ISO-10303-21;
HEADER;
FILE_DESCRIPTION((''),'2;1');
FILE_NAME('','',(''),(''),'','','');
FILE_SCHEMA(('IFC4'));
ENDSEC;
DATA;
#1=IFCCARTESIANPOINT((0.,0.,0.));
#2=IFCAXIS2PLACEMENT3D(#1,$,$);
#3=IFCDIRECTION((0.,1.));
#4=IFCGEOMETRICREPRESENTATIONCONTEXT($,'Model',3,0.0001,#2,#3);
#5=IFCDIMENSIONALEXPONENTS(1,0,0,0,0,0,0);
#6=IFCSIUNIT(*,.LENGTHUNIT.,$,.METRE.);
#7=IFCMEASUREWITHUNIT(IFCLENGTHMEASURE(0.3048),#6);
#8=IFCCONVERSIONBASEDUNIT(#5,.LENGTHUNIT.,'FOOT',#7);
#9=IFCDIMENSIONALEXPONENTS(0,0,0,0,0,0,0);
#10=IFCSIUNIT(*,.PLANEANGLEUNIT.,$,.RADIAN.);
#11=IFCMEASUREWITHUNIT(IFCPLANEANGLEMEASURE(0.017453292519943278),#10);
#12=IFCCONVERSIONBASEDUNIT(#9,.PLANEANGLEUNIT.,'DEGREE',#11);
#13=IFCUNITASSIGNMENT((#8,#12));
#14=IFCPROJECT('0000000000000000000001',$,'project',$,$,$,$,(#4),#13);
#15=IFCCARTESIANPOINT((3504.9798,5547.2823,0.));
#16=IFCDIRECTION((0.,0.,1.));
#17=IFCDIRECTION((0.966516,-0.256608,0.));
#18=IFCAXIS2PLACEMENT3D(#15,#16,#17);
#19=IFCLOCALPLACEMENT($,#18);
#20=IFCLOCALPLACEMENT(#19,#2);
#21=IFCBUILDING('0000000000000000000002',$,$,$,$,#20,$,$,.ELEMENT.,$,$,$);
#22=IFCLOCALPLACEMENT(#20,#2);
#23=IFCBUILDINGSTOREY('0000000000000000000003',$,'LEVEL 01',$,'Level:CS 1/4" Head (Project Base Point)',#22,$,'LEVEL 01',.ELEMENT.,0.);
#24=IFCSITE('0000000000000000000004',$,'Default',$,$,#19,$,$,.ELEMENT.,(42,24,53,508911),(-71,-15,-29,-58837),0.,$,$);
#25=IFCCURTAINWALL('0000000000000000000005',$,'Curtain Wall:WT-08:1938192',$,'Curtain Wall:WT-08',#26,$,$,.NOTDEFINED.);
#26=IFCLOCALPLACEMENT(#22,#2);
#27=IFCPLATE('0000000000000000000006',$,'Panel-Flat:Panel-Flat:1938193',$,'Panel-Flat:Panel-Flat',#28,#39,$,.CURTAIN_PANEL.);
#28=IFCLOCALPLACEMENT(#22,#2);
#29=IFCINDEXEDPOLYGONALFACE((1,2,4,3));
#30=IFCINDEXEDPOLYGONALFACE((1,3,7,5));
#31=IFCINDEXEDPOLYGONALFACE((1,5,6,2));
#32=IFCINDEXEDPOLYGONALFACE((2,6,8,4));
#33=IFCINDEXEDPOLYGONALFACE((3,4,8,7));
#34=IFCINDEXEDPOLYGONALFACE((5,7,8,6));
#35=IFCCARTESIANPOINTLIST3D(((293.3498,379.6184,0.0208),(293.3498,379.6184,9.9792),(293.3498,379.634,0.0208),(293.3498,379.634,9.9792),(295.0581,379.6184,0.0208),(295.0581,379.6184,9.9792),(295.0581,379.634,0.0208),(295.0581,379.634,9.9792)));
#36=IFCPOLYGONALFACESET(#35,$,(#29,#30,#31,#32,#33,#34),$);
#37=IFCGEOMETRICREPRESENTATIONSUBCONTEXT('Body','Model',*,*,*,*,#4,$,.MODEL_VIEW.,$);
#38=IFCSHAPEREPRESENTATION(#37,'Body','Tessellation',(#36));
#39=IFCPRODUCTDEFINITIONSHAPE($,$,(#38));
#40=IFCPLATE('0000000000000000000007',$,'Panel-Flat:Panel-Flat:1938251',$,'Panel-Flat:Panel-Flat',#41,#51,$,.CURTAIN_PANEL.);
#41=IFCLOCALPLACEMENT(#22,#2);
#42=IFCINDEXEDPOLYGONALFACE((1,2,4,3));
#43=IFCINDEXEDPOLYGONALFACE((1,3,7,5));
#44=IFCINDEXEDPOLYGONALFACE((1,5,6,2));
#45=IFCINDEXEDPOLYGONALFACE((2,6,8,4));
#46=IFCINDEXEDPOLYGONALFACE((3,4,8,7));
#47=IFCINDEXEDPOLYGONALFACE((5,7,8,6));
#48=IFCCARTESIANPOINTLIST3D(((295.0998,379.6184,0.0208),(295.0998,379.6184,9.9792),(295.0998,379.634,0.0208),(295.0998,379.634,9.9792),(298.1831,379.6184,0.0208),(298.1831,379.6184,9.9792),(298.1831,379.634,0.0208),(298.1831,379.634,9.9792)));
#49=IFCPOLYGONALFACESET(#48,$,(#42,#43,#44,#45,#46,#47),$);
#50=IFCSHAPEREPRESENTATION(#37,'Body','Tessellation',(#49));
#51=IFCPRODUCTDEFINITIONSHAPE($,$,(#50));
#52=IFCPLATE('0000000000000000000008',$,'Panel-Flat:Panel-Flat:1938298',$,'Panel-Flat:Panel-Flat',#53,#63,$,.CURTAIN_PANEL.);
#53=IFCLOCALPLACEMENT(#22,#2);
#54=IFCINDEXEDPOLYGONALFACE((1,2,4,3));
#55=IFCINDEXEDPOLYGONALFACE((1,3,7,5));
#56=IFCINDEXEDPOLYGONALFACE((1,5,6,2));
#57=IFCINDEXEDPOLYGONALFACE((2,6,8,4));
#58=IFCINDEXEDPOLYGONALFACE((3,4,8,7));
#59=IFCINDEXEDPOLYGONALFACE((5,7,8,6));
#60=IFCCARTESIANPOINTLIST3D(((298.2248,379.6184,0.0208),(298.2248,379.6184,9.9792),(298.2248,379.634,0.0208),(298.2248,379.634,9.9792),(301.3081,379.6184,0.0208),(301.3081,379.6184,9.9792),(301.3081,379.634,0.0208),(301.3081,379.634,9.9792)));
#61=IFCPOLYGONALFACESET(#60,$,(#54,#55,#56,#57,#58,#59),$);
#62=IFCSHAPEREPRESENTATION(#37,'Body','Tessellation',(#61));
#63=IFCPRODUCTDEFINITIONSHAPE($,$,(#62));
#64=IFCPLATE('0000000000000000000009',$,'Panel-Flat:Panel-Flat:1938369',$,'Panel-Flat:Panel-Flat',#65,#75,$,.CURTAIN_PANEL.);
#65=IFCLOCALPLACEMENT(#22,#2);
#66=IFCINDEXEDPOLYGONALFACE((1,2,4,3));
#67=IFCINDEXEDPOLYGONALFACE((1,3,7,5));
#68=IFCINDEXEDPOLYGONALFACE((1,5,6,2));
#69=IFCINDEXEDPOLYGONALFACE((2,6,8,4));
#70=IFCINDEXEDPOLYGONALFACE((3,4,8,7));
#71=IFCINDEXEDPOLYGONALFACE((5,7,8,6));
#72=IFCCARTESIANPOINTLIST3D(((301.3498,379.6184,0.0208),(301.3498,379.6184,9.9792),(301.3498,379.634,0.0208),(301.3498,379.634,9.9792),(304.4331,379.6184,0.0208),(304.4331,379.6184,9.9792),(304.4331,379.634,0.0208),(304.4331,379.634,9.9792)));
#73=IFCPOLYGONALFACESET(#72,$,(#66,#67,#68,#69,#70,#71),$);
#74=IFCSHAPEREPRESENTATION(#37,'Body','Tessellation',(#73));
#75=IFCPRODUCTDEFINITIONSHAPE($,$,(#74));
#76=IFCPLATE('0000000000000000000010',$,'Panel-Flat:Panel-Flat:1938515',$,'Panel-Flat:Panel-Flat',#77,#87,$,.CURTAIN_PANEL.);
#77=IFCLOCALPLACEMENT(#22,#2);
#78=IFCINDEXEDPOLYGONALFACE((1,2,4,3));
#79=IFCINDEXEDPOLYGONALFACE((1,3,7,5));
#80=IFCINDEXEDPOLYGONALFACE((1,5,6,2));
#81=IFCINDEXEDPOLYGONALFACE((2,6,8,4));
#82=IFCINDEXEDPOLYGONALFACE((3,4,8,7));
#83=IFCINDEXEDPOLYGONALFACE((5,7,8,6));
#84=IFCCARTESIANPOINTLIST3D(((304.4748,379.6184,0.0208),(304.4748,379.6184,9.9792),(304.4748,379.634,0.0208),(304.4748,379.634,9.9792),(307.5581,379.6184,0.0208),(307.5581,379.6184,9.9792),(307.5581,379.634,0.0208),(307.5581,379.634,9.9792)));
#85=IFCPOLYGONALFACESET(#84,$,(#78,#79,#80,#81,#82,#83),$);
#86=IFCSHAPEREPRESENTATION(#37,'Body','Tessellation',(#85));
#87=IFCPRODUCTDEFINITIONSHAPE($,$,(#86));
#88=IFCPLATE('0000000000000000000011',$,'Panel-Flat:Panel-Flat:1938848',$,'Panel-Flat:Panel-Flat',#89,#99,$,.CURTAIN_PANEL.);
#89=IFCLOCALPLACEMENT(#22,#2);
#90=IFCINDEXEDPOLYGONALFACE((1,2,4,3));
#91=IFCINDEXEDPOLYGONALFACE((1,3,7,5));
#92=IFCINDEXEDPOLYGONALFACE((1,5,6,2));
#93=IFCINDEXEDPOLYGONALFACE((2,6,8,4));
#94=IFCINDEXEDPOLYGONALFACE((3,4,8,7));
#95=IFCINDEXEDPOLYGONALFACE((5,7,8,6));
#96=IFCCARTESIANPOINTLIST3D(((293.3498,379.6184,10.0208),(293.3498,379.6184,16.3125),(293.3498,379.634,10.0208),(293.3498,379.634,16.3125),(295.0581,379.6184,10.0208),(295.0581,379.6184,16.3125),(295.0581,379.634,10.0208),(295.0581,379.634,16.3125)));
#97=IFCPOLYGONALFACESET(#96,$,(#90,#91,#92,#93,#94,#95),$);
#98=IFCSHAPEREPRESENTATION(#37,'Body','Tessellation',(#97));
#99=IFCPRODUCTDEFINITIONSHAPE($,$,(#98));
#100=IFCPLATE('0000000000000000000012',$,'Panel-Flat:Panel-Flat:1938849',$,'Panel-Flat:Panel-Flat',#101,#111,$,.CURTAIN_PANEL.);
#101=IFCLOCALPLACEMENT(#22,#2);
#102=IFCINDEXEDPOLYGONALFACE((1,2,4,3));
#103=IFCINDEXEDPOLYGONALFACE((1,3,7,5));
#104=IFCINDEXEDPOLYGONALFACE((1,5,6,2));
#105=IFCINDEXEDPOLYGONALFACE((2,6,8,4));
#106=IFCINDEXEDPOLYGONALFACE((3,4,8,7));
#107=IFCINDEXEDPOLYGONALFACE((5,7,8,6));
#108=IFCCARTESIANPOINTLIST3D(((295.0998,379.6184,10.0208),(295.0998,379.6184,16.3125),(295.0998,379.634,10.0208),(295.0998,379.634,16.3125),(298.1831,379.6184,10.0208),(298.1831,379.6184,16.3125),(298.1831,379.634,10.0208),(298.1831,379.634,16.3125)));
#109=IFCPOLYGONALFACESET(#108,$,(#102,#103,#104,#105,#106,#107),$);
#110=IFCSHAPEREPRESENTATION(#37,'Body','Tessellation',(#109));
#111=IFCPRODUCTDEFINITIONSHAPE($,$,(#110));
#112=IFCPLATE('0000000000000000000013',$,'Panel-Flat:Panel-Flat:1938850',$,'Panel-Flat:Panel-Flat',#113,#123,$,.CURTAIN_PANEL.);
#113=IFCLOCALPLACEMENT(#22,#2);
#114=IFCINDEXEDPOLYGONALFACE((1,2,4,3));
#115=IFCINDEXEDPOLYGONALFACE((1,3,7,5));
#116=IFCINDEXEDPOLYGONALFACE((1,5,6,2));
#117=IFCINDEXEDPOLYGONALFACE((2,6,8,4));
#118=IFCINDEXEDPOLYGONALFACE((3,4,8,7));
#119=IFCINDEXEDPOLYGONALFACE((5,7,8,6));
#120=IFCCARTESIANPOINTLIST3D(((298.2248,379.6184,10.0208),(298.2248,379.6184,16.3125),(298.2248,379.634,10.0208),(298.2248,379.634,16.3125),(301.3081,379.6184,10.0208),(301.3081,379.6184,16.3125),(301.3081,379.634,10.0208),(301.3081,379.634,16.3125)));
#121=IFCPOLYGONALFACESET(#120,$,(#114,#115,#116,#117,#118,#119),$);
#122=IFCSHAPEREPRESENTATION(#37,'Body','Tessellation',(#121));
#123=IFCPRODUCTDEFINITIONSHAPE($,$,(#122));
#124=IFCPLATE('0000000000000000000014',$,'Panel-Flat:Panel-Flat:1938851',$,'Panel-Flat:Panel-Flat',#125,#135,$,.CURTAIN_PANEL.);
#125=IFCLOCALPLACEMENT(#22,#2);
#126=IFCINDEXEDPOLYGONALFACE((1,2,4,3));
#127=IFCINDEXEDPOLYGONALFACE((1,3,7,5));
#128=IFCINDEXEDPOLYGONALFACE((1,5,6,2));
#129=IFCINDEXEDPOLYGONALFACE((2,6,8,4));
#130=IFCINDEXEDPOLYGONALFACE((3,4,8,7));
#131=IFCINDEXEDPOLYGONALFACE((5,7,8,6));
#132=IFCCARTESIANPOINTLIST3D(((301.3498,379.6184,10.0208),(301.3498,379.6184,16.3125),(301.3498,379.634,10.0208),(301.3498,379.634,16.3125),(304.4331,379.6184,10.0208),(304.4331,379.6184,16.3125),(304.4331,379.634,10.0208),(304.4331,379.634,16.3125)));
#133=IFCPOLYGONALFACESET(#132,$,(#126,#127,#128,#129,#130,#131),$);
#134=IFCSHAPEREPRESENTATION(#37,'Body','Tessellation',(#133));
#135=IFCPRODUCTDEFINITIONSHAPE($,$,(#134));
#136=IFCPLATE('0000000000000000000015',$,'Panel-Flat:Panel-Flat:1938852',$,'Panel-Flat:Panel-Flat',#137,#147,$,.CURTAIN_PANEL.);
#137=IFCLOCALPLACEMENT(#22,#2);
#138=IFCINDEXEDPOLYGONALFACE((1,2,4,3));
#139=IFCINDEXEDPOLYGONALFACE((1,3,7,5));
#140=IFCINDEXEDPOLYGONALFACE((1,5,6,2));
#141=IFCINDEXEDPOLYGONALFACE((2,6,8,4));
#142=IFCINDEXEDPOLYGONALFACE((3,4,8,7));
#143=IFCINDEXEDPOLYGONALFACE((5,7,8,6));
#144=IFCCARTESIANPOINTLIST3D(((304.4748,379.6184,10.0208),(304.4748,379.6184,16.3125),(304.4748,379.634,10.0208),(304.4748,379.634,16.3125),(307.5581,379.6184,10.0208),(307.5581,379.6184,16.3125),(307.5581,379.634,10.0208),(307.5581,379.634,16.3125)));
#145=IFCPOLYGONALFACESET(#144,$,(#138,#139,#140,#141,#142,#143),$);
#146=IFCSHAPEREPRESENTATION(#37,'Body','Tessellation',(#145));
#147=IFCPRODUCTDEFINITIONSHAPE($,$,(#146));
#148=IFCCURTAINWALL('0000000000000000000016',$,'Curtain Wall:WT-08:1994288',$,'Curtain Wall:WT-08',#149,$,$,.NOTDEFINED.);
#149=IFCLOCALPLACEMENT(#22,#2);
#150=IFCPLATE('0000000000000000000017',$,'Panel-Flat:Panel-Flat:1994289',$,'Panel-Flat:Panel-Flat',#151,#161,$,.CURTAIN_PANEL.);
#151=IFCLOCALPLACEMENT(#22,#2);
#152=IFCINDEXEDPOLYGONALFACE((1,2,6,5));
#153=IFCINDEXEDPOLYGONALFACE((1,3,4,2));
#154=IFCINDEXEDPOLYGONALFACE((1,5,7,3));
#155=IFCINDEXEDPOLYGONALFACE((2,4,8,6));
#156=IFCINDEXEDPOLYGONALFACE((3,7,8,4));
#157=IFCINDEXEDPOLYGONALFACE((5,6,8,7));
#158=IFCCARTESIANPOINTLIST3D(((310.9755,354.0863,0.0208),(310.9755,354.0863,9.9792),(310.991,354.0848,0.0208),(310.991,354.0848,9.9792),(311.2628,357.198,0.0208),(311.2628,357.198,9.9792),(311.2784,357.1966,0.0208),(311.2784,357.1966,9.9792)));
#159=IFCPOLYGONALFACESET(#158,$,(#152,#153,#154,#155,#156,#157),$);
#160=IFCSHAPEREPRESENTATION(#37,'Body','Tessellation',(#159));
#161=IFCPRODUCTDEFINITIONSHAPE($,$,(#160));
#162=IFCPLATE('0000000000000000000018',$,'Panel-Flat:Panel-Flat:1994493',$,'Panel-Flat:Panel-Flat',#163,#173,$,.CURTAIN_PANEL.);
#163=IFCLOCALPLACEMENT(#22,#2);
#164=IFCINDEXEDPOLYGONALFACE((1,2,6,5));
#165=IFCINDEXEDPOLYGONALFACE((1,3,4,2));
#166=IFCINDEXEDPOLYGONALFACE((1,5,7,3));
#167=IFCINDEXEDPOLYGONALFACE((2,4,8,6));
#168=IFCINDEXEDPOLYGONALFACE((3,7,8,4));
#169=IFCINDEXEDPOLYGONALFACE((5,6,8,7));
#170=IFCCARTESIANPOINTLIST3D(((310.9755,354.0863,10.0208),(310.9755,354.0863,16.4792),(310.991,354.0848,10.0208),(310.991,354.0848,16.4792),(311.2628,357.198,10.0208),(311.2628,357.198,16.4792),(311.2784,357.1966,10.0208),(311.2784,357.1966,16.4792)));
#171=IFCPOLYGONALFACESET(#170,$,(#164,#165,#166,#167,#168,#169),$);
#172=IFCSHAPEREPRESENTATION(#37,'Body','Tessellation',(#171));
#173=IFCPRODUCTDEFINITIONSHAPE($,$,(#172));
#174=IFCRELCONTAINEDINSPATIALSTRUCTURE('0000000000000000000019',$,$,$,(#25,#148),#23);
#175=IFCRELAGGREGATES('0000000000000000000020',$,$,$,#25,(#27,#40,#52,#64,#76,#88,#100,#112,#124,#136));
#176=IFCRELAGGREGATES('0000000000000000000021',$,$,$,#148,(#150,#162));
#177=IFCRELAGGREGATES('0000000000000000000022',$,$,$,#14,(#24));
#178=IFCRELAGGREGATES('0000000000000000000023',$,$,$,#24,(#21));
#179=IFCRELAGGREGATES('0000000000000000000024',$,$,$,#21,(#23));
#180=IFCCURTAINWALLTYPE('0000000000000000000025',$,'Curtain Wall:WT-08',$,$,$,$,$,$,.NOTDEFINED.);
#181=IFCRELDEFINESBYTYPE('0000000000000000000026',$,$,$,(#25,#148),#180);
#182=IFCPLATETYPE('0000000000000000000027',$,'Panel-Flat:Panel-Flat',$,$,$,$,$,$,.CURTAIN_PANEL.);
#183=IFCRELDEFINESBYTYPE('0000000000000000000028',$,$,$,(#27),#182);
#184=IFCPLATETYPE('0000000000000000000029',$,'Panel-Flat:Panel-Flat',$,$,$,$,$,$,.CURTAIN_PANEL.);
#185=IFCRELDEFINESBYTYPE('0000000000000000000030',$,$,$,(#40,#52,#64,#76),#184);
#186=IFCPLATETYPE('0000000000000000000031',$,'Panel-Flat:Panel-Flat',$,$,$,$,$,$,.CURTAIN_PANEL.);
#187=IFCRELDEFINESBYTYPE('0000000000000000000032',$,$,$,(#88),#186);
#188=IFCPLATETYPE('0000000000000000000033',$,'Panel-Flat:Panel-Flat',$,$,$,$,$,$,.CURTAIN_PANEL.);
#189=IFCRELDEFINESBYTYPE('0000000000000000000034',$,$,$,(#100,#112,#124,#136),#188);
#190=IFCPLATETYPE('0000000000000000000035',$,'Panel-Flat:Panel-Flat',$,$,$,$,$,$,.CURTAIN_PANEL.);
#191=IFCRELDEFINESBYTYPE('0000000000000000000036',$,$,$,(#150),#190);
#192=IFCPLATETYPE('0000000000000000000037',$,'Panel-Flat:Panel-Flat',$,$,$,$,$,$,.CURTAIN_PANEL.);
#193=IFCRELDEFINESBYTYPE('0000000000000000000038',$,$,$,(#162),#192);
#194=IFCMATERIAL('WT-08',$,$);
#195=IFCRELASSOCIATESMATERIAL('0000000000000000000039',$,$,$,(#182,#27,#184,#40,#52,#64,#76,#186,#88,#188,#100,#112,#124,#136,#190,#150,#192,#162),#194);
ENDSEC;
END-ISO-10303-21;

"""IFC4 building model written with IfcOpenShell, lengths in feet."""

from ifc_helpers import new_model, entity, si_unit, converted_unit, direction, frame, origin, place, context, subcontext, project, spatial, indexed_curve, outline, extrude, source, transform, mapped, material, type_object, type_shapes, element, aggregate, save


model = new_model("IFC4")

# Units and contexts
model_context = context("Model", 3, precision=0.0001, world=origin(), true_north=direction((0.0, 1.0)))
body_context = subcontext(model_context, "Body", "Model", "MODEL_VIEW")
ifc_project = project(units=[converted_unit("LENGTHUNIT", "FOOT", entity("IfcLengthMeasure", 0.3048), si_unit("LENGTHUNIT", "METRE"), dimensions=[1, 0, 0, 0, 0, 0, 0]), converted_unit("PLANEANGLEUNIT", "DEGREE", entity("IfcPlaneAngleMeasure", 0.017453292519943278), si_unit("PLANEANGLEUNIT", "RADIAN"), dimensions=[0, 0, 0, 0, 0, 0, 0])], contexts=[model_context])

# Site, building, storey
site_placement = place(None, frame((3504.9798, 5547.2823, 0.0), z_axis=(0.0, 0.0, 1.0), x_axis=(0.966516, -0.256608, 0.0)))
site = spatial("IfcSite", under=ifc_project, at=site_placement, Name="Default", CompositionType="ELEMENT", RefLatitude=(42, 24, 53, 508911), RefLongitude=(-71, -15, -29, -58837), RefElevation=0.0)
building_placement = place(site_placement, origin())
building = spatial("IfcBuilding", under=site, at=building_placement, CompositionType="ELEMENT")
storey_placement = place(building_placement, origin())
storey = spatial("IfcBuildingStorey", under=building, at=storey_placement, Name="LEVEL 01", ObjectType="Level:CS 1/4\" Head (Project Base Point)", LongName="LEVEL 01", CompositionType="ELEMENT", Elevation=0.0)

# Curtain walls, plates
curtain_wall_type_1 = type_object("IfcCurtainWallType", Name="Curtain Wall:WT-08", PredefinedType="NOTDEFINED")
curtain_wall_1_placement = place(storey_placement, origin())
curtain_wall_1 = element("IfcCurtainWall", 1, at=curtain_wall_1_placement, inside=storey, type_object=curtain_wall_type_1, Name="Curtain Wall:WT-08:1938192", ObjectType="Curtain Wall:WT-08", PredefinedType="NOTDEFINED")
ifc_material_1 = material(Name="WT-08")
plate_type_1 = type_object("IfcPlateType", Name="Panel-Flat:Panel-Flat", PredefinedType="CURTAIN_PANEL", material=ifc_material_1)
shared_shape_1 = source(origin(), body_context, "Body", "SweptSolid", [
    extrude(outline(indexed_curve([(-0.0078, -0.8542), (0.0078, -0.8542), (0.0078, 0.8542), (-0.0078, 0.8542), (-0.0078, -0.8542)], self_intersect=False)), frame((0.8542, 0.0078, 0.0), z_axis=(0.0, 0.0, 1.0), x_axis=(0.0, -1.0, 0.0)), (0.0, 0.0, 1.0), 9.9583),
])
type_shapes(plate_type_1, [shared_shape_1])
plate_1_placement = place(curtain_wall_1_placement, frame((293.3498, 379.6184, 0.0208)))
plate_1 = element("IfcPlate", 2, at=plate_1_placement, type_object=plate_type_1, material=ifc_material_1, Name="Panel-Flat:Panel-Flat:1938193", ObjectType="Panel-Flat:Panel-Flat", PredefinedType="CURTAIN_PANEL", context=body_context, shape_type="MappedRepresentation", body=[
    mapped(shared_shape_1, transform((0.0, 0.0, 0.0), scale=1.0)),
])
plate_type_2 = type_object("IfcPlateType", Name="Panel-Flat:Panel-Flat", PredefinedType="CURTAIN_PANEL", material=ifc_material_1)
shared_shape_2 = source(origin(), body_context, "Body", "SweptSolid", [
    extrude(outline(indexed_curve([(-0.0078, -1.5417), (0.0078, -1.5417), (0.0078, 1.5417), (-0.0078, 1.5417), (-0.0078, -1.5417)], self_intersect=False)), frame((1.5417, 0.0078, 0.0), z_axis=(0.0, 0.0, 1.0), x_axis=(0.0, -1.0, 0.0)), (0.0, 0.0, 1.0), 9.9583),
])
type_shapes(plate_type_2, [shared_shape_2])
plate_2_placement = place(curtain_wall_1_placement, frame((295.0998, 379.6184, 0.0208)))
plate_2 = element("IfcPlate", 3, at=plate_2_placement, type_object=plate_type_2, material=ifc_material_1, Name="Panel-Flat:Panel-Flat:1938251", ObjectType="Panel-Flat:Panel-Flat", PredefinedType="CURTAIN_PANEL", context=body_context, shape_type="MappedRepresentation", body=[
    mapped(shared_shape_2, transform((0.0, 0.0, 0.0), scale=1.0)),
])
plate_3_placement = place(curtain_wall_1_placement, frame((298.2248, 379.6184, 0.0208)))
plate_3 = element("IfcPlate", 4, at=plate_3_placement, type_object=plate_type_2, material=ifc_material_1, Name="Panel-Flat:Panel-Flat:1938298", ObjectType="Panel-Flat:Panel-Flat", PredefinedType="CURTAIN_PANEL", context=body_context, shape_type="MappedRepresentation", body=[
    mapped(shared_shape_2, transform((0.0, 0.0, 0.0), scale=1.0)),
])
plate_4_placement = place(curtain_wall_1_placement, frame((301.3498, 379.6184, 0.0208)))
plate_4 = element("IfcPlate", 5, at=plate_4_placement, type_object=plate_type_2, material=ifc_material_1, Name="Panel-Flat:Panel-Flat:1938369", ObjectType="Panel-Flat:Panel-Flat", PredefinedType="CURTAIN_PANEL", context=body_context, shape_type="MappedRepresentation", body=[
    mapped(shared_shape_2, transform((0.0, 0.0, 0.0), scale=1.0)),
])
plate_5_placement = place(curtain_wall_1_placement, frame((304.4748, 379.6184, 0.0208)))
plate_5 = element("IfcPlate", 6, at=plate_5_placement, type_object=plate_type_2, material=ifc_material_1, Name="Panel-Flat:Panel-Flat:1938515", ObjectType="Panel-Flat:Panel-Flat", PredefinedType="CURTAIN_PANEL", context=body_context, shape_type="MappedRepresentation", body=[
    mapped(shared_shape_2, transform((0.0, 0.0, 0.0), scale=1.0)),
])
plate_type_3 = type_object("IfcPlateType", Name="Panel-Flat:Panel-Flat", PredefinedType="CURTAIN_PANEL", material=ifc_material_1)
shared_shape_3 = source(origin(), body_context, "Body", "SweptSolid", [
    extrude(outline(indexed_curve([(-0.0078, -0.8542), (0.0078, -0.8542), (0.0078, 0.8542), (-0.0078, 0.8542), (-0.0078, -0.8542)], self_intersect=False)), frame((0.8542, 0.0078, 0.0), z_axis=(0.0, 0.0, 1.0), x_axis=(0.0, -1.0, 0.0)), (0.0, 0.0, 1.0), 6.2917),
])
type_shapes(plate_type_3, [shared_shape_3])
plate_6_placement = place(curtain_wall_1_placement, frame((293.3498, 379.6184, 10.0208)))
plate_6 = element("IfcPlate", 7, at=plate_6_placement, type_object=plate_type_3, material=ifc_material_1, Name="Panel-Flat:Panel-Flat:1938848", ObjectType="Panel-Flat:Panel-Flat", PredefinedType="CURTAIN_PANEL", context=body_context, shape_type="MappedRepresentation", body=[
    mapped(shared_shape_3, transform((0.0, 0.0, 0.0), scale=1.0)),
])
plate_type_4 = type_object("IfcPlateType", Name="Panel-Flat:Panel-Flat", PredefinedType="CURTAIN_PANEL", material=ifc_material_1)
shared_shape_4 = source(origin(), body_context, "Body", "SweptSolid", [
    extrude(outline(indexed_curve([(-0.0078, -1.5417), (0.0078, -1.5417), (0.0078, 1.5417), (-0.0078, 1.5417), (-0.0078, -1.5417)], self_intersect=False)), frame((1.5417, 0.0078, 0.0), z_axis=(0.0, 0.0, 1.0), x_axis=(0.0, -1.0, 0.0)), (0.0, 0.0, 1.0), 6.2917),
])
type_shapes(plate_type_4, [shared_shape_4])
plate_7_placement = place(curtain_wall_1_placement, frame((295.0998, 379.6184, 10.0208)))
plate_7 = element("IfcPlate", 8, at=plate_7_placement, type_object=plate_type_4, material=ifc_material_1, Name="Panel-Flat:Panel-Flat:1938849", ObjectType="Panel-Flat:Panel-Flat", PredefinedType="CURTAIN_PANEL", context=body_context, shape_type="MappedRepresentation", body=[
    mapped(shared_shape_4, transform((0.0, 0.0, 0.0), scale=1.0)),
])
plate_8_placement = place(curtain_wall_1_placement, frame((298.2248, 379.6184, 10.0208)))
plate_8 = element("IfcPlate", 9, at=plate_8_placement, type_object=plate_type_4, material=ifc_material_1, Name="Panel-Flat:Panel-Flat:1938850", ObjectType="Panel-Flat:Panel-Flat", PredefinedType="CURTAIN_PANEL", context=body_context, shape_type="MappedRepresentation", body=[
    mapped(shared_shape_4, transform((0.0, 0.0, 0.0), scale=1.0)),
])
plate_9_placement = place(curtain_wall_1_placement, frame((301.3498, 379.6184, 10.0208)))
plate_9 = element("IfcPlate", 10, at=plate_9_placement, type_object=plate_type_4, material=ifc_material_1, Name="Panel-Flat:Panel-Flat:1938851", ObjectType="Panel-Flat:Panel-Flat", PredefinedType="CURTAIN_PANEL", context=body_context, shape_type="MappedRepresentation", body=[
    mapped(shared_shape_4, transform((0.0, 0.0, 0.0), scale=1.0)),
])
plate_10_placement = place(curtain_wall_1_placement, frame((304.4748, 379.6184, 10.0208)))
plate_10 = element("IfcPlate", 11, at=plate_10_placement, type_object=plate_type_4, material=ifc_material_1, Name="Panel-Flat:Panel-Flat:1938852", ObjectType="Panel-Flat:Panel-Flat", PredefinedType="CURTAIN_PANEL", context=body_context, shape_type="MappedRepresentation", body=[
    mapped(shared_shape_4, transform((0.0, 0.0, 0.0), scale=1.0)),
])
aggregate(curtain_wall_1, [plate_1, plate_2, plate_3, plate_4, plate_5, plate_6, plate_7, plate_8, plate_9, plate_10])
curtain_wall_2_placement = place(storey_placement, origin())
curtain_wall_2 = element("IfcCurtainWall", 12, at=curtain_wall_2_placement, inside=storey, type_object=curtain_wall_type_1, Name="Curtain Wall:WT-08:1994288", ObjectType="Curtain Wall:WT-08", PredefinedType="NOTDEFINED")
plate_type_5 = type_object("IfcPlateType", Name="Panel-Flat:Panel-Flat", PredefinedType="CURTAIN_PANEL", material=ifc_material_1)
shared_shape_5 = source(origin(), body_context, "Body", "SweptSolid", [
    extrude(outline(indexed_curve([(-0.0078, -1.5625), (0.0078, -1.5625), (0.0078, 1.5625), (-0.0078, 1.5625), (-0.0078, -1.5625)], self_intersect=False)), frame((1.5625, 0.0078, 0.0), z_axis=(0.0, 0.0, 1.0), x_axis=(0.0, -1.0, 0.0)), (0.0, 0.0, 1.0), 9.9583),
])
type_shapes(plate_type_5, [shared_shape_5])
plate_11_placement = place(curtain_wall_2_placement, frame((311.2628, 357.198, 0.0208), z_axis=(0.0, 0.0, 1.0), x_axis=(-0.091962, -0.995763, 0.0)))
plate_11 = element("IfcPlate", 13, at=plate_11_placement, type_object=plate_type_5, material=ifc_material_1, Name="Panel-Flat:Panel-Flat:1994289", ObjectType="Panel-Flat:Panel-Flat", PredefinedType="CURTAIN_PANEL", context=body_context, shape_type="MappedRepresentation", body=[
    mapped(shared_shape_5, transform((0.0, 0.0, 0.0), scale=1.0)),
])
plate_type_6 = type_object("IfcPlateType", Name="Panel-Flat:Panel-Flat", PredefinedType="CURTAIN_PANEL", material=ifc_material_1)
shared_shape_6 = source(origin(), body_context, "Body", "SweptSolid", [
    extrude(outline(indexed_curve([(-0.0078, -1.5625), (0.0078, -1.5625), (0.0078, 1.5625), (-0.0078, 1.5625), (-0.0078, -1.5625)], self_intersect=False)), frame((1.5625, 0.0078, 0.0), z_axis=(0.0, 0.0, 1.0), x_axis=(0.0, -1.0, 0.0)), (0.0, 0.0, 1.0), 6.4583),
])
type_shapes(plate_type_6, [shared_shape_6])
plate_12_placement = place(curtain_wall_2_placement, frame((311.2628, 357.198, 10.0208), z_axis=(0.0, 0.0, 1.0), x_axis=(-0.091962, -0.995763, 0.0)))
plate_12 = element("IfcPlate", 14, at=plate_12_placement, type_object=plate_type_6, material=ifc_material_1, Name="Panel-Flat:Panel-Flat:1994493", ObjectType="Panel-Flat:Panel-Flat", PredefinedType="CURTAIN_PANEL", context=body_context, shape_type="MappedRepresentation", body=[
    mapped(shared_shape_6, transform((0.0, 0.0, 0.0), scale=1.0)),
])
aggregate(curtain_wall_2, [plate_11, plate_12])

save(model, "model.ifc")
